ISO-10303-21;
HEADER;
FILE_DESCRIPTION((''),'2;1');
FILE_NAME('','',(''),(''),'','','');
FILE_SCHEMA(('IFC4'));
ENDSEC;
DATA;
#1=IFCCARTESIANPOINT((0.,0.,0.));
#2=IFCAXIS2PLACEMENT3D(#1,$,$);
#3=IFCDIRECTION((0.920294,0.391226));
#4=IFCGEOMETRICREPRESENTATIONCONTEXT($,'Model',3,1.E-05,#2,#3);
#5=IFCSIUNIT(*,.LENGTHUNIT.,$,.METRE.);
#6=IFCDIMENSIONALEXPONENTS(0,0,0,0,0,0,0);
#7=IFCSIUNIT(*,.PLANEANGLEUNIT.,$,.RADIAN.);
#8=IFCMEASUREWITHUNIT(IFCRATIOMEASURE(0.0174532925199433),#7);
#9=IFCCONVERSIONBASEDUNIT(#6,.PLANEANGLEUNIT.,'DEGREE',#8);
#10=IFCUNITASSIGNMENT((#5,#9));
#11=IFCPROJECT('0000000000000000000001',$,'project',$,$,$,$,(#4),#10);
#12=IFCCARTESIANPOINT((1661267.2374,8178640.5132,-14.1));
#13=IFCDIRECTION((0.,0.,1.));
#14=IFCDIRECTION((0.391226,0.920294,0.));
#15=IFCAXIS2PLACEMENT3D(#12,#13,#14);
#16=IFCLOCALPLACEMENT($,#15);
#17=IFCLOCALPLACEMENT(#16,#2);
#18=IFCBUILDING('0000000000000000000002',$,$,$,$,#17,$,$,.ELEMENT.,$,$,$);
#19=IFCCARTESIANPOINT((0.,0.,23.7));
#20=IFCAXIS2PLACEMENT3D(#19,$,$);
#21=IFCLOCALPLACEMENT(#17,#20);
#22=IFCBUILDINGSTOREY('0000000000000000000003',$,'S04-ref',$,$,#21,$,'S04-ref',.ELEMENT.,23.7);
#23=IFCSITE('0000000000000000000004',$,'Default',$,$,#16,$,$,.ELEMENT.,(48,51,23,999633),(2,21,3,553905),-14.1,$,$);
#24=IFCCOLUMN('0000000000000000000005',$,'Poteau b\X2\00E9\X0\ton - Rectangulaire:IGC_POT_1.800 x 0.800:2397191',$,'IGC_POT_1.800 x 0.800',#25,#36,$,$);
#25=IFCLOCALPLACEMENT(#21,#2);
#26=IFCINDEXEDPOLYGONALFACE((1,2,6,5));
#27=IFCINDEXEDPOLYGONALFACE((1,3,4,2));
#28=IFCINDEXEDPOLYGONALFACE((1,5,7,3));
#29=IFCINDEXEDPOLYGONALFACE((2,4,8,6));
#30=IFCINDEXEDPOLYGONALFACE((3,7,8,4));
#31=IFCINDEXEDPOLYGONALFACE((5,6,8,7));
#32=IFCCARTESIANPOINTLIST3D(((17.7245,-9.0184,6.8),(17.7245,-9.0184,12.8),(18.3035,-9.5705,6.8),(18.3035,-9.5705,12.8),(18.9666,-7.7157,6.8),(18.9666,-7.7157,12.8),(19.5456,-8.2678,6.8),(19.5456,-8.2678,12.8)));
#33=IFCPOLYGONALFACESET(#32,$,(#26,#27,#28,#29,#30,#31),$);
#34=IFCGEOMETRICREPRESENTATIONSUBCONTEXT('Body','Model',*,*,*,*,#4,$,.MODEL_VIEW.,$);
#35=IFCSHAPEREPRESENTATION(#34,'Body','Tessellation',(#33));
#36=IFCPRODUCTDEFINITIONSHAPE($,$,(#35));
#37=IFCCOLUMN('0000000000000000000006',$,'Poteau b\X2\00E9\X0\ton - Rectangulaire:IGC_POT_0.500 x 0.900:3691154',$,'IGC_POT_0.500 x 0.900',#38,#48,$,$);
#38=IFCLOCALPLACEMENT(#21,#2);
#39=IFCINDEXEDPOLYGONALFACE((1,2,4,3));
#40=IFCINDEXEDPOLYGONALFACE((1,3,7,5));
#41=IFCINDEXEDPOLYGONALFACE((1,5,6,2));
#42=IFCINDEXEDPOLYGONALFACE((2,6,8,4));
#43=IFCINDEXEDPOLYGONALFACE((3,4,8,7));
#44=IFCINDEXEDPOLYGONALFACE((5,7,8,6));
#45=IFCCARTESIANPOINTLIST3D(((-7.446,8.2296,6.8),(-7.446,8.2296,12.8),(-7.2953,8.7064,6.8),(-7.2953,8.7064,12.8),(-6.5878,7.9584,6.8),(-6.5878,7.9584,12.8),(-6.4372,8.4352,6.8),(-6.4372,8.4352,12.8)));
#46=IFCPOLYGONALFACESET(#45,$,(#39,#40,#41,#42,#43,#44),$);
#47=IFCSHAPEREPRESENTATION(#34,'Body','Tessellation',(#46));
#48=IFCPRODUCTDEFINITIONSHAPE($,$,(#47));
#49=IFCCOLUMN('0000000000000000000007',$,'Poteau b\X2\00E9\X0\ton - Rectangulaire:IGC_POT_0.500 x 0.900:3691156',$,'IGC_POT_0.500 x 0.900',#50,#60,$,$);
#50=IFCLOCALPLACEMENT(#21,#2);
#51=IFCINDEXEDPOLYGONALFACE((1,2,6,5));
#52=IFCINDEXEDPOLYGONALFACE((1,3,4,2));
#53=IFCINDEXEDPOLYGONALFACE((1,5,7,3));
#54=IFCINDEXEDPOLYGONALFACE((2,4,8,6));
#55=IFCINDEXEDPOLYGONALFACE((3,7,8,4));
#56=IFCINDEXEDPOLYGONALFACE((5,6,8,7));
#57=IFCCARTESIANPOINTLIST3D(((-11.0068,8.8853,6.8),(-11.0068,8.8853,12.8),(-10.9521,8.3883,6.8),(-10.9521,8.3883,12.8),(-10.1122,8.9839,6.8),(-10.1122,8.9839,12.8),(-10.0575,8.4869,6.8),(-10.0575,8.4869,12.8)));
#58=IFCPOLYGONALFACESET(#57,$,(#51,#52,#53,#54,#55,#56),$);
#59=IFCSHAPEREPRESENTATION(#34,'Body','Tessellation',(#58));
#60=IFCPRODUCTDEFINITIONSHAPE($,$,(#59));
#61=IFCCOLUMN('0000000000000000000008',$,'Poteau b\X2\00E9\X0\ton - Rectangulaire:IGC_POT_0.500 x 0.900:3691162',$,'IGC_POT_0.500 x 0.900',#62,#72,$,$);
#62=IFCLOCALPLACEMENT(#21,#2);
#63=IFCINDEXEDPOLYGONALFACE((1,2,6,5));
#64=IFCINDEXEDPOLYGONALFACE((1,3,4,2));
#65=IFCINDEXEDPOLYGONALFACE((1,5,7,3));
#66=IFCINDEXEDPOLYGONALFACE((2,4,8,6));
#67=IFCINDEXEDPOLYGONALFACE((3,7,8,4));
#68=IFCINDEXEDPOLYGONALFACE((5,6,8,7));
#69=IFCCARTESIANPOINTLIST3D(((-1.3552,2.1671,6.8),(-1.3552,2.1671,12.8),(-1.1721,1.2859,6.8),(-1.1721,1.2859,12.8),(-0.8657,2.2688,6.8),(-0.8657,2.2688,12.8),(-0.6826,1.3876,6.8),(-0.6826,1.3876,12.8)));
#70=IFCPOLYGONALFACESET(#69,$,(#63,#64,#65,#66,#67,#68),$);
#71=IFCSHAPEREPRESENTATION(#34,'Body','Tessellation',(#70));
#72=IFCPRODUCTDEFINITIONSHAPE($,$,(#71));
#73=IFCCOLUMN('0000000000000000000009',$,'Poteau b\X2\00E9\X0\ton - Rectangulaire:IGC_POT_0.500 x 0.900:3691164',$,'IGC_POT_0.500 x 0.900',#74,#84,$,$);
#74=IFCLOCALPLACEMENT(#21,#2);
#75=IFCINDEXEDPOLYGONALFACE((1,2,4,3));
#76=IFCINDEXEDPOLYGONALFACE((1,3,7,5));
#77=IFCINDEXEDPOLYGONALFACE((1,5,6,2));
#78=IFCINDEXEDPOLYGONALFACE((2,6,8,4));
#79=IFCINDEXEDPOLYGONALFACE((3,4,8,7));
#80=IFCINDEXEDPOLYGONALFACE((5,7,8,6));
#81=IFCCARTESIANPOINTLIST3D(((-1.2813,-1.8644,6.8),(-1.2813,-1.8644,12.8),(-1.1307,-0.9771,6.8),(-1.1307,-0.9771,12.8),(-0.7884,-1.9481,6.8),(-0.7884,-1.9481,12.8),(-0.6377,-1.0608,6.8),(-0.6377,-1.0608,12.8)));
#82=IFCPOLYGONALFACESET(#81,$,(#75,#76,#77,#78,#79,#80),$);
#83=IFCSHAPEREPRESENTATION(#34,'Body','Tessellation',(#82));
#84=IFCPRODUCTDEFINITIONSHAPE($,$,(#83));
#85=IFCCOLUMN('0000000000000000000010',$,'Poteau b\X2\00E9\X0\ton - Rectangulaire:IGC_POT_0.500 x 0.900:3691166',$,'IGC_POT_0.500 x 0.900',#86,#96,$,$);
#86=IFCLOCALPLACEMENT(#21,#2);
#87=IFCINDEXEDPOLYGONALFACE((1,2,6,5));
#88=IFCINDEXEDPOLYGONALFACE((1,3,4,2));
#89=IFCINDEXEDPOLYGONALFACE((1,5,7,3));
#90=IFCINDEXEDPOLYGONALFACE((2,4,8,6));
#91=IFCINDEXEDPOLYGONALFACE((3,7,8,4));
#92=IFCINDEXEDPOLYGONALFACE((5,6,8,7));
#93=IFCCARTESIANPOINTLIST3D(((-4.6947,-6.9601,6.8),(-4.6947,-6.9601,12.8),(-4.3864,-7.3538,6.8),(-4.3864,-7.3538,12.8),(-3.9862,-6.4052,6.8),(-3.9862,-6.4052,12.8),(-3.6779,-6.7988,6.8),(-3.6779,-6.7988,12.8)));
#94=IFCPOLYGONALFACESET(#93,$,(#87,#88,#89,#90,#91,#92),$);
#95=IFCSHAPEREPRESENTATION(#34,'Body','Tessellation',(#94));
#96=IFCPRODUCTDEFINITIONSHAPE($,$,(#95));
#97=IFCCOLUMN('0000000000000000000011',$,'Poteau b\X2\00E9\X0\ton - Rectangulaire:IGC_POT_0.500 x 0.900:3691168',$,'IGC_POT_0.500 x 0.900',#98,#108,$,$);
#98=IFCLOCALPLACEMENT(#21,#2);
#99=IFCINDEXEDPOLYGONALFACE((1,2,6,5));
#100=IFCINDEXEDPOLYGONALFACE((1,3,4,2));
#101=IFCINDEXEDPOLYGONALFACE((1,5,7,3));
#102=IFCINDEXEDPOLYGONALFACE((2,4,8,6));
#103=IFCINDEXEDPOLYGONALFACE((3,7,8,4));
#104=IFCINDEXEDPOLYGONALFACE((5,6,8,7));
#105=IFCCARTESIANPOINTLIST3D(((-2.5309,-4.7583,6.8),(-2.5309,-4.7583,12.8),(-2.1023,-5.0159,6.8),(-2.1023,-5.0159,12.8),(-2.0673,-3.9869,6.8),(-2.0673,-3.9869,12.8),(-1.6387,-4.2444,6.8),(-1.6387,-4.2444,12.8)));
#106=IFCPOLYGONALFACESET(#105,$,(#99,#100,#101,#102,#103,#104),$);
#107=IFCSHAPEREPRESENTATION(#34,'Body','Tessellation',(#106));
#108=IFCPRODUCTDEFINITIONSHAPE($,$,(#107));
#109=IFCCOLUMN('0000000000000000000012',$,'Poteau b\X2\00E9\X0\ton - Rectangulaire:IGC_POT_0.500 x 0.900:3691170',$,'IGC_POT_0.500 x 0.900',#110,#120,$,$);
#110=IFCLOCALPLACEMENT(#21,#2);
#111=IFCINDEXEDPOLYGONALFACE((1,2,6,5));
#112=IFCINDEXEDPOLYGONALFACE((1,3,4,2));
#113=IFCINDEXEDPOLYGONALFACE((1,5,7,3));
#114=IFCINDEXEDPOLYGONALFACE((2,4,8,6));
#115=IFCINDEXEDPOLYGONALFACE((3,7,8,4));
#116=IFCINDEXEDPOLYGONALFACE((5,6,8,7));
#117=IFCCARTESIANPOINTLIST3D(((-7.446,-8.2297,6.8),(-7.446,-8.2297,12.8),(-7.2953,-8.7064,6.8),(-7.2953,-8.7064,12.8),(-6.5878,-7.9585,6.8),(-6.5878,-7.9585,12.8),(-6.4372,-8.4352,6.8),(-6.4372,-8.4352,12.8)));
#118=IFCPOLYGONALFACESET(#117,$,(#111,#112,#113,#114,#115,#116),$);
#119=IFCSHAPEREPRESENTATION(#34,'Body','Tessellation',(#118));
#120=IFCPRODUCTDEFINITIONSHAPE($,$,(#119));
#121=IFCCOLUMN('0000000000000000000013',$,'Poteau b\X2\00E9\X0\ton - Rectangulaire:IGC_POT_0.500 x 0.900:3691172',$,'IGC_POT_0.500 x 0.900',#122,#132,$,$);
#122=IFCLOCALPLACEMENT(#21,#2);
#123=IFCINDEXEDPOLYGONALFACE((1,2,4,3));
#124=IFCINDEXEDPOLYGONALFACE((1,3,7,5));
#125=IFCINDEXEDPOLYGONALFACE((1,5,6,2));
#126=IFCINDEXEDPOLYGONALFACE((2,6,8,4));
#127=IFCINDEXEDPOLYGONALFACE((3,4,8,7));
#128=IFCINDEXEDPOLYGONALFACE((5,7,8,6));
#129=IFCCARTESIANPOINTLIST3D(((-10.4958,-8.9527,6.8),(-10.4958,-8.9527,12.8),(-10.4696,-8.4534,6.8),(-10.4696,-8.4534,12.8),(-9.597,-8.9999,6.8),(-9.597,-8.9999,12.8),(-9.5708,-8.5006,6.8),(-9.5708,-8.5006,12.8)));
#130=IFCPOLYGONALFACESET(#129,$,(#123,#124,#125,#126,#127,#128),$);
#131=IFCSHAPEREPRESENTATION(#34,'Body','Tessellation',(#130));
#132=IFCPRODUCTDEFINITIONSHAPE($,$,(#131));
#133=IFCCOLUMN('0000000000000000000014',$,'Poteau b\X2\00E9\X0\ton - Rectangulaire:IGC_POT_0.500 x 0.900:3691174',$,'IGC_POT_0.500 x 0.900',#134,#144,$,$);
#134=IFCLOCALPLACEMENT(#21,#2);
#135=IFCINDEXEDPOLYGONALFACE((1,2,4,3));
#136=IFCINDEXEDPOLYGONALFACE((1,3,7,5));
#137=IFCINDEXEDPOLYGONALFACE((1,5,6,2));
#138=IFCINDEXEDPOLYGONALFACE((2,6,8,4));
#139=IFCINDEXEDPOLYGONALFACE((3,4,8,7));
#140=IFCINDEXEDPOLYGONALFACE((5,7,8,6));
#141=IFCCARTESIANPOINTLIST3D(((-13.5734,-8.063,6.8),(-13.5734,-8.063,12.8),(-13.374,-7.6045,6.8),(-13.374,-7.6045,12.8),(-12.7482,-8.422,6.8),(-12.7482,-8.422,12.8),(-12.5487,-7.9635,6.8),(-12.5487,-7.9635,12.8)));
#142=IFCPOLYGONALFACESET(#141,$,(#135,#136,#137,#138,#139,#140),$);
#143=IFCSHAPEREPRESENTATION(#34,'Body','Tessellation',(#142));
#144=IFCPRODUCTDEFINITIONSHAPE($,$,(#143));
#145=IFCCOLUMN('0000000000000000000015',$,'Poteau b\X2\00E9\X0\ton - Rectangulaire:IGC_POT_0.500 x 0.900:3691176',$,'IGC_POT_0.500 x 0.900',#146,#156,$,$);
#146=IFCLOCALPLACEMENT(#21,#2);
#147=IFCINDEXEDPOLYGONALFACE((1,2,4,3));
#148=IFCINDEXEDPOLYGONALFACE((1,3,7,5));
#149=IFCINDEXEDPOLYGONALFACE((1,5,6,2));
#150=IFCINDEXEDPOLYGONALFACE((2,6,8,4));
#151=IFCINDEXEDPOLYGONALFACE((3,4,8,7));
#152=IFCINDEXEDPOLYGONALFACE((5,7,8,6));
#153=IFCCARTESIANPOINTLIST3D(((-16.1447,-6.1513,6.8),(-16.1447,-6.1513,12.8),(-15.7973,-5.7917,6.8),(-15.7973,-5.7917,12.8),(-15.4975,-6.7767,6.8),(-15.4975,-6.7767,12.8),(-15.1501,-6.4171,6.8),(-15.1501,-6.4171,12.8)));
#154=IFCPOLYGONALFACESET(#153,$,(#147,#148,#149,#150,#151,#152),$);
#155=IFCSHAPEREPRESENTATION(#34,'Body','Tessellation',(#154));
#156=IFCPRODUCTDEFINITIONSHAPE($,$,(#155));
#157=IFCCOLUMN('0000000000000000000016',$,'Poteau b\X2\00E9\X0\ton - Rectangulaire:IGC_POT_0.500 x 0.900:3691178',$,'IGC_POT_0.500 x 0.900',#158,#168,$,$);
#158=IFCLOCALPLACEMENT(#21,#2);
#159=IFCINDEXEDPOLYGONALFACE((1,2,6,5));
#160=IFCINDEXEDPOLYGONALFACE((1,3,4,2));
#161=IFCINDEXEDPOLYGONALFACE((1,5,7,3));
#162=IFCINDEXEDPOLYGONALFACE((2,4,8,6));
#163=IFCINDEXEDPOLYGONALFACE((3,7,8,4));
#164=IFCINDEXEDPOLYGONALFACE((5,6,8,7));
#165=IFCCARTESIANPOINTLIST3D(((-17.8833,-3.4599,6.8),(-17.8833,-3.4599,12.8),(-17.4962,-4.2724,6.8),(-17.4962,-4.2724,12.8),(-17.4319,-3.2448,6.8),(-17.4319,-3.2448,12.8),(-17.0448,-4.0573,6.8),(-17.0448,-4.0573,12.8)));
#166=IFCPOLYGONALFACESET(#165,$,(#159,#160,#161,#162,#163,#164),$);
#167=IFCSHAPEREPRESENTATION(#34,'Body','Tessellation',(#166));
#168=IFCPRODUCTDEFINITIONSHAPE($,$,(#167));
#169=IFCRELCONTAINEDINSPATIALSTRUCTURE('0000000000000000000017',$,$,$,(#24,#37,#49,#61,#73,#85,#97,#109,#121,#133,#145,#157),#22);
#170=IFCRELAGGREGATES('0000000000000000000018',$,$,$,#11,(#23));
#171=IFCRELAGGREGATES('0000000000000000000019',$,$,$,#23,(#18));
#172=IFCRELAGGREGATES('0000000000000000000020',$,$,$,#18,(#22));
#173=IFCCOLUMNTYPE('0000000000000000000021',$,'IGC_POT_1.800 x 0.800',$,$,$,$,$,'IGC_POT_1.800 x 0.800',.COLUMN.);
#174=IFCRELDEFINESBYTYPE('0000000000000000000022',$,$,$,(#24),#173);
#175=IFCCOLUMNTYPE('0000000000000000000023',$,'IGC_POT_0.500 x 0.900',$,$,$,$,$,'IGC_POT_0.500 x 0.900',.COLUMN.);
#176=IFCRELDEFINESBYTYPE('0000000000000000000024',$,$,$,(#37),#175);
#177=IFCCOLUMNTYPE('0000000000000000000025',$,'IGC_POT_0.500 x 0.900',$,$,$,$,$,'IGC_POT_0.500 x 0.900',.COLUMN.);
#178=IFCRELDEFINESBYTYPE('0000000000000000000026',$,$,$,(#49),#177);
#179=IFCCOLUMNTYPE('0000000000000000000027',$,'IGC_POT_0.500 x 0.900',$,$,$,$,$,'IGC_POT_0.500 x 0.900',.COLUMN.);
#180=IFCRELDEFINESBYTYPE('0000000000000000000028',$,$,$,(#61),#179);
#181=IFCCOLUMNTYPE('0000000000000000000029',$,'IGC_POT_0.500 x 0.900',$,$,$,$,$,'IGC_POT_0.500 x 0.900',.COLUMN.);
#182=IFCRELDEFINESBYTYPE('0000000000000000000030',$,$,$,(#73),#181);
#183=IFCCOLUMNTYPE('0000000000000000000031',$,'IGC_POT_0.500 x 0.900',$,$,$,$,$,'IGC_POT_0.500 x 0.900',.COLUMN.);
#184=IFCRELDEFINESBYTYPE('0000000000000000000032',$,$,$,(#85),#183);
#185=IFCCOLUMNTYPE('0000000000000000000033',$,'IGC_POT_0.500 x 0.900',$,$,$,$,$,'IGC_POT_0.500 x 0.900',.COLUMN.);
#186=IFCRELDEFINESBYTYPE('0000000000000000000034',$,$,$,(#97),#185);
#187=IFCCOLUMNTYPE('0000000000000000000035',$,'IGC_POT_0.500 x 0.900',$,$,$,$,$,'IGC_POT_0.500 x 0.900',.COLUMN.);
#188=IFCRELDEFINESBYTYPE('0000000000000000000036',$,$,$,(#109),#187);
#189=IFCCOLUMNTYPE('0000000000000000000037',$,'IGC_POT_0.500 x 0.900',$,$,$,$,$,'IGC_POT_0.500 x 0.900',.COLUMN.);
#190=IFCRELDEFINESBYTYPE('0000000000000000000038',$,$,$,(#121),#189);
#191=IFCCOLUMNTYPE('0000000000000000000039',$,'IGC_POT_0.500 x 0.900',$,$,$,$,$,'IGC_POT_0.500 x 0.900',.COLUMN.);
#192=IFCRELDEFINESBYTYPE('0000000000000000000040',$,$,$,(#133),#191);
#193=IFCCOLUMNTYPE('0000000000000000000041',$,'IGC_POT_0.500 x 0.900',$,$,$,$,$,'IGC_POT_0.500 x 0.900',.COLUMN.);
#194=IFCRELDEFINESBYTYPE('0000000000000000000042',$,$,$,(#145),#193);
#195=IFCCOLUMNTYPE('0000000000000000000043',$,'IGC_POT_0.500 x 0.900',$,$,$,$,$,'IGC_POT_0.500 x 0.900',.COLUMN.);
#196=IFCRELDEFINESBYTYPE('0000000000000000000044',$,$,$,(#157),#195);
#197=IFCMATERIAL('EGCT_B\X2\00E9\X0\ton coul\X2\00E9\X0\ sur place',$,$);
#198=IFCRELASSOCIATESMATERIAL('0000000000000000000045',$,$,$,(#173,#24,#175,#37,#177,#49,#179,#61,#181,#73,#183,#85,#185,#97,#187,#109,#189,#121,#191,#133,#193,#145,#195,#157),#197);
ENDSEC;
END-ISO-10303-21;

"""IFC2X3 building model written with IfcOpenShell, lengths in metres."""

from ifc_helpers import new_model, entity, si_unit, converted_unit, direction, frame, frame_2d, origin, origin_2d_with_axis, place, context, subcontext, project, spatial, rectangle, extrude, source, transform, mapped, material, type_object, type_shapes, element, save


model = new_model("IFC2X3")

# Units and contexts
model_context = context("Model", 3, precision=1e-05, world=origin(), true_north=direction((0.920294, 0.391226)))
body_context = subcontext(model_context, "Body", "Model", "MODEL_VIEW")
ifc_project = project(units=[si_unit("LENGTHUNIT", "METRE"), converted_unit("PLANEANGLEUNIT", "DEGREE", entity("IfcRatioMeasure", 0.0174532925199433), si_unit("PLANEANGLEUNIT", "RADIAN"), dimensions=[0, 0, 0, 0, 0, 0, 0])], contexts=[model_context])

# Site, building, storey
site_placement = place(None, frame((1661267.2374, 8178640.5132, -14.1), z_axis=(0.0, 0.0, 1.0), x_axis=(0.391226, 0.920294, 0.0)))
site = spatial("IfcSite", under=ifc_project, at=site_placement, Name="Default", CompositionType="ELEMENT", RefLatitude=(48, 51, 23, 999633), RefLongitude=(2, 21, 3, 553905), RefElevation=-14.1)
building_placement = place(site_placement, origin())
building = spatial("IfcBuilding", under=site, at=building_placement, CompositionType="ELEMENT")
storey_placement = place(building_placement, frame((0.0, 0.0, 23.7)))
storey = spatial("IfcBuildingStorey", under=building, at=storey_placement, Name="S04-ref", LongName="S04-ref", CompositionType="ELEMENT", Elevation=23.7)

# Columns
ifc_material_1 = material(Name="EGCT_Béton coulé sur place")
column_type_1 = type_object("IfcColumnType", Name="IGC_POT_1.800 x 0.800", ElementType="IGC_POT_1.800 x 0.800", PredefinedType="COLUMN", material=ifc_material_1)
shared_shape_1 = source(origin(), body_context, "Body", "SweptSolid", [
    extrude(rectangle(XDim=0.8, YDim=1.8, at=frame_2d((0.0, 0.0), x_axis=(1.0, 0.0))), frame((18.6351, -8.6431, 30.5), z_axis=(0.0, 0.0, 1.0), x_axis=(-0.723727, 0.690086, 0.0)), (0.0, 0.0, 1.0), 6.0),
])
type_shapes(column_type_1, [shared_shape_1])
column_1_placement = place(storey_placement, frame((0.0, 0.0, -23.7)))
element("IfcColumn", 1, at=column_1_placement, inside=storey, type_object=column_type_1, material=ifc_material_1, Name="Poteau béton - Rectangulaire:IGC_POT_1.800 x 0.800:2397191", ObjectType="IGC_POT_1.800 x 0.800", context=body_context, shape_type="MappedRepresentation", body=[
    mapped(shared_shape_1, transform((0.0, 0.0, 0.0), scale=1.0)),
])
column_type_2 = type_object("IfcColumnType", Name="IGC_POT_0.500 x 0.900", ElementType="IGC_POT_0.500 x 0.900", PredefinedType="COLUMN", material=ifc_material_1)
shared_shape_2 = source(origin(), body_context, "Body", "SweptSolid", [
    extrude(rectangle(XDim=0.9, YDim=0.5, at=origin_2d_with_axis()), frame((-6.9416, 8.3324, 30.5), z_axis=(0.0, 0.0, 1.0), x_axis=(-0.953513, 0.301352, 0.0)), (0.0, 0.0, 1.0), 6.0),
])
type_shapes(column_type_2, [shared_shape_2])
column_2_placement = place(storey_placement, frame((0.0, 0.0, -23.7)))
element("IfcColumn", 2, at=column_2_placement, inside=storey, type_object=column_type_2, material=ifc_material_1, Name="Poteau béton - Rectangulaire:IGC_POT_0.500 x 0.900:3691154", ObjectType="IGC_POT_0.500 x 0.900", context=body_context, shape_type="MappedRepresentation", body=[
    mapped(shared_shape_2, transform((0.0, 0.0, 0.0), scale=1.0)),
])
column_type_3 = type_object("IfcColumnType", Name="IGC_POT_0.500 x 0.900", ElementType="IGC_POT_0.500 x 0.900", PredefinedType="COLUMN", material=ifc_material_1)
shared_shape_3 = source(origin(), body_context, "Body", "SweptSolid", [
    extrude(rectangle(XDim=0.9, YDim=0.5, at=frame_2d((0.0, 0.0), x_axis=(1.0, 0.0))), frame((-10.5321, 8.6861, 30.5), z_axis=(0.0, 0.0, 1.0), x_axis=(-0.993983, -0.10953, 0.0)), (0.0, 0.0, 1.0), 6.0),
])
type_shapes(column_type_3, [shared_shape_3])
column_3_placement = place(storey_placement, frame((0.0, 0.0, -23.7)))
element("IfcColumn", 3, at=column_3_placement, inside=storey, type_object=column_type_3, material=ifc_material_1, Name="Poteau béton - Rectangulaire:IGC_POT_0.500 x 0.900:3691156", ObjectType="IGC_POT_0.500 x 0.900", context=body_context, shape_type="MappedRepresentation", body=[
    mapped(shared_shape_3, transform((0.0, 0.0, 0.0), scale=1.0)),
])
column_type_4 = type_object("IfcColumnType", Name="IGC_POT_0.500 x 0.900", ElementType="IGC_POT_0.500 x 0.900", PredefinedType="COLUMN", material=ifc_material_1)
shared_shape_4 = source(origin(), body_context, "Body", "SweptSolid", [
    extrude(rectangle(XDim=0.9, YDim=0.5, at=origin_2d_with_axis()), frame((-1.0189, 1.7774, 30.5), z_axis=(0.0, 0.0, 1.0), x_axis=(-0.203394, 0.979097, 0.0)), (0.0, 0.0, 1.0), 6.0),
])
type_shapes(column_type_4, [shared_shape_4])
column_4_placement = place(storey_placement, frame((0.0, 0.0, -23.7)))
element("IfcColumn", 4, at=column_4_placement, inside=storey, type_object=column_type_4, material=ifc_material_1, Name="Poteau béton - Rectangulaire:IGC_POT_0.500 x 0.900:3691162", ObjectType="IGC_POT_0.500 x 0.900", context=body_context, shape_type="MappedRepresentation", body=[
    mapped(shared_shape_4, transform((0.0, 0.0, 0.0), scale=1.0)),
])
column_type_5 = type_object("IfcColumnType", Name="IGC_POT_0.500 x 0.900", ElementType="IGC_POT_0.500 x 0.900", PredefinedType="COLUMN", material=ifc_material_1)
shared_shape_5 = source(origin(), body_context, "Body", "SweptSolid", [
    extrude(rectangle(XDim=0.9, YDim=0.5, at=frame_2d((0.0, 0.0), x_axis=(1.0, 0.0))), frame((-0.9595, -1.4626, 30.5), z_axis=(0.0, 0.0, 1.0), x_axis=(0.167362, 0.985895, 0.0)), (0.0, 0.0, 1.0), 6.0),
])
type_shapes(column_type_5, [shared_shape_5])
column_5_placement = place(storey_placement, frame((0.0, 0.0, -23.7)))
element("IfcColumn", 5, at=column_5_placement, inside=storey, type_object=column_type_5, material=ifc_material_1, Name="Poteau béton - Rectangulaire:IGC_POT_0.500 x 0.900:3691164", ObjectType="IGC_POT_0.500 x 0.900", context=body_context, shape_type="MappedRepresentation", body=[
    mapped(shared_shape_5, transform((0.0, 0.0, 0.0), scale=1.0)),
])
column_type_6 = type_object("IfcColumnType", Name="IGC_POT_0.500 x 0.900", ElementType="IGC_POT_0.500 x 0.900", PredefinedType="COLUMN", material=ifc_material_1)
shared_shape_6 = source(origin(), body_context, "Body", "SweptSolid", [
    extrude(rectangle(XDim=0.9, YDim=0.5, at=origin_2d_with_axis()), frame((-4.1863, -6.8795, 30.5), z_axis=(0.0, 0.0, 1.0), x_axis=(0.787239, 0.616648, 0.0)), (0.0, 0.0, 1.0), 6.0),
])
type_shapes(column_type_6, [shared_shape_6])
column_6_placement = place(storey_placement, frame((0.0, 0.0, -23.7)))
element("IfcColumn", 6, at=column_6_placement, inside=storey, type_object=column_type_6, material=ifc_material_1, Name="Poteau béton - Rectangulaire:IGC_POT_0.500 x 0.900:3691166", ObjectType="IGC_POT_0.500 x 0.900", context=body_context, shape_type="MappedRepresentation", body=[
    mapped(shared_shape_6, transform((0.0, 0.0, 0.0), scale=1.0)),
])
column_type_7 = type_object("IfcColumnType", Name="IGC_POT_0.500 x 0.900", ElementType="IGC_POT_0.500 x 0.900", PredefinedType="COLUMN", material=ifc_material_1)
shared_shape_7 = source(origin(), body_context, "Body", "SweptSolid", [
    extrude(rectangle(XDim=0.9, YDim=0.5, at=frame_2d((0.0, 0.0), x_axis=(1.0, 0.0))), frame((-2.0848, -4.5014, 30.5), z_axis=(0.0, 0.0, 1.0), x_axis=(0.515106, 0.857126, 0.0)), (0.0, 0.0, 1.0), 6.0),
])
type_shapes(column_type_7, [shared_shape_7])
column_7_placement = place(storey_placement, frame((0.0, 0.0, -23.7)))
element("IfcColumn", 7, at=column_7_placement, inside=storey, type_object=column_type_7, material=ifc_material_1, Name="Poteau béton - Rectangulaire:IGC_POT_0.500 x 0.900:3691168", ObjectType="IGC_POT_0.500 x 0.900", context=body_context, shape_type="MappedRepresentation", body=[
    mapped(shared_shape_7, transform((0.0, 0.0, 0.0), scale=1.0)),
])
column_type_8 = type_object("IfcColumnType", Name="IGC_POT_0.500 x 0.900", ElementType="IGC_POT_0.500 x 0.900", PredefinedType="COLUMN", material=ifc_material_1)
shared_shape_8 = source(origin(), body_context, "Body", "SweptSolid", [
    extrude(rectangle(XDim=0.5, YDim=0.9, at=origin_2d_with_axis()), frame((-6.9416, -8.3325, 30.5), z_axis=(0.0, 0.0, 1.0), x_axis=(-0.301353, 0.953513, 0.0)), (0.0, 0.0, 1.0), 6.0),
])
type_shapes(column_type_8, [shared_shape_8])
column_8_placement = place(storey_placement, frame((0.0, 0.0, -23.7)))
element("IfcColumn", 8, at=column_8_placement, inside=storey, type_object=column_type_8, material=ifc_material_1, Name="Poteau béton - Rectangulaire:IGC_POT_0.500 x 0.900:3691170", ObjectType="IGC_POT_0.500 x 0.900", context=body_context, shape_type="MappedRepresentation", body=[
    mapped(shared_shape_8, transform((0.0, 0.0, 0.0), scale=1.0)),
])
column_type_9 = type_object("IfcColumnType", Name="IGC_POT_0.500 x 0.900", ElementType="IGC_POT_0.500 x 0.900", PredefinedType="COLUMN", material=ifc_material_1)
shared_shape_9 = source(origin(), body_context, "Body", "SweptSolid", [
    extrude(rectangle(XDim=0.5, YDim=0.9, at=frame_2d((0.0, 0.0), x_axis=(1.0, 0.0))), frame((-10.0333, -8.7267, 30.5), z_axis=(0.0, 0.0, 1.0), x_axis=(0.052447, 0.998624, 0.0)), (0.0, 0.0, 1.0), 6.0),
])
type_shapes(column_type_9, [shared_shape_9])
column_9_placement = place(storey_placement, frame((0.0, 0.0, -23.7)))
element("IfcColumn", 9, at=column_9_placement, inside=storey, type_object=column_type_9, material=ifc_material_1, Name="Poteau béton - Rectangulaire:IGC_POT_0.500 x 0.900:3691172", ObjectType="IGC_POT_0.500 x 0.900", context=body_context, shape_type="MappedRepresentation", body=[
    mapped(shared_shape_9, transform((0.0, 0.0, 0.0), scale=1.0)),
])
column_type_10 = type_object("IfcColumnType", Name="IGC_POT_0.500 x 0.900", ElementType="IGC_POT_0.500 x 0.900", PredefinedType="COLUMN", material=ifc_material_1)
shared_shape_10 = source(origin(), body_context, "Body", "SweptSolid", [
    extrude(rectangle(XDim=0.9, YDim=0.5, at=frame_2d((0.0, 0.0), x_axis=(1.0, 0.0))), frame((-13.0611, -8.0132, 30.5), z_axis=(0.0, 0.0, 1.0), x_axis=(-0.916984, 0.398923, 0.0)), (0.0, 0.0, 1.0), 6.0),
])
type_shapes(column_type_10, [shared_shape_10])
column_10_placement = place(storey_placement, frame((0.0, 0.0, -23.7)))
element("IfcColumn", 10, at=column_10_placement, inside=storey, type_object=column_type_10, material=ifc_material_1, Name="Poteau béton - Rectangulaire:IGC_POT_0.500 x 0.900:3691174", ObjectType="IGC_POT_0.500 x 0.900", context=body_context, shape_type="MappedRepresentation", body=[
    mapped(shared_shape_10, transform((0.0, 0.0, 0.0), scale=1.0)),
])
column_type_11 = type_object("IfcColumnType", Name="IGC_POT_0.500 x 0.900", ElementType="IGC_POT_0.500 x 0.900", PredefinedType="COLUMN", material=ifc_material_1)
shared_shape_11 = source(origin(), body_context, "Body", "SweptSolid", [
    extrude(rectangle(XDim=0.9, YDim=0.5, at=origin_2d_with_axis()), frame((-15.6474, -6.2842, 30.5), z_axis=(0.0, 0.0, 1.0), x_axis=(-0.719121, 0.694885, 0.0)), (0.0, 0.0, 1.0), 6.0),
])
type_shapes(column_type_11, [shared_shape_11])
column_11_placement = place(storey_placement, frame((0.0, 0.0, -23.7)))
element("IfcColumn", 11, at=column_11_placement, inside=storey, type_object=column_type_11, material=ifc_material_1, Name="Poteau béton - Rectangulaire:IGC_POT_0.500 x 0.900:3691176", ObjectType="IGC_POT_0.500 x 0.900", context=body_context, shape_type="MappedRepresentation", body=[
    mapped(shared_shape_11, transform((0.0, 0.0, 0.0), scale=1.0)),
])
column_type_12 = type_object("IfcColumnType", Name="IGC_POT_0.500 x 0.900", ElementType="IGC_POT_0.500 x 0.900", PredefinedType="COLUMN", material=ifc_material_1)
shared_shape_12 = source(origin(), body_context, "Body", "SweptSolid", [
    extrude(rectangle(XDim=0.9, YDim=0.5, at=frame_2d((0.0, 0.0), x_axis=(1.0, 0.0))), frame((-17.4641, -3.7586, 30.5), z_axis=(0.0, 0.0, 1.0), x_axis=(-0.430108, 0.902777, 0.0)), (0.0, 0.0, 1.0), 6.0),
])
type_shapes(column_type_12, [shared_shape_12])
column_12_placement = place(storey_placement, frame((0.0, 0.0, -23.7)))
element("IfcColumn", 12, at=column_12_placement, inside=storey, type_object=column_type_12, material=ifc_material_1, Name="Poteau béton - Rectangulaire:IGC_POT_0.500 x 0.900:3691178", ObjectType="IGC_POT_0.500 x 0.900", context=body_context, shape_type="MappedRepresentation", body=[
    mapped(shared_shape_12, transform((0.0, 0.0, 0.0), scale=1.0)),
])

save(model, "model.ifc")
